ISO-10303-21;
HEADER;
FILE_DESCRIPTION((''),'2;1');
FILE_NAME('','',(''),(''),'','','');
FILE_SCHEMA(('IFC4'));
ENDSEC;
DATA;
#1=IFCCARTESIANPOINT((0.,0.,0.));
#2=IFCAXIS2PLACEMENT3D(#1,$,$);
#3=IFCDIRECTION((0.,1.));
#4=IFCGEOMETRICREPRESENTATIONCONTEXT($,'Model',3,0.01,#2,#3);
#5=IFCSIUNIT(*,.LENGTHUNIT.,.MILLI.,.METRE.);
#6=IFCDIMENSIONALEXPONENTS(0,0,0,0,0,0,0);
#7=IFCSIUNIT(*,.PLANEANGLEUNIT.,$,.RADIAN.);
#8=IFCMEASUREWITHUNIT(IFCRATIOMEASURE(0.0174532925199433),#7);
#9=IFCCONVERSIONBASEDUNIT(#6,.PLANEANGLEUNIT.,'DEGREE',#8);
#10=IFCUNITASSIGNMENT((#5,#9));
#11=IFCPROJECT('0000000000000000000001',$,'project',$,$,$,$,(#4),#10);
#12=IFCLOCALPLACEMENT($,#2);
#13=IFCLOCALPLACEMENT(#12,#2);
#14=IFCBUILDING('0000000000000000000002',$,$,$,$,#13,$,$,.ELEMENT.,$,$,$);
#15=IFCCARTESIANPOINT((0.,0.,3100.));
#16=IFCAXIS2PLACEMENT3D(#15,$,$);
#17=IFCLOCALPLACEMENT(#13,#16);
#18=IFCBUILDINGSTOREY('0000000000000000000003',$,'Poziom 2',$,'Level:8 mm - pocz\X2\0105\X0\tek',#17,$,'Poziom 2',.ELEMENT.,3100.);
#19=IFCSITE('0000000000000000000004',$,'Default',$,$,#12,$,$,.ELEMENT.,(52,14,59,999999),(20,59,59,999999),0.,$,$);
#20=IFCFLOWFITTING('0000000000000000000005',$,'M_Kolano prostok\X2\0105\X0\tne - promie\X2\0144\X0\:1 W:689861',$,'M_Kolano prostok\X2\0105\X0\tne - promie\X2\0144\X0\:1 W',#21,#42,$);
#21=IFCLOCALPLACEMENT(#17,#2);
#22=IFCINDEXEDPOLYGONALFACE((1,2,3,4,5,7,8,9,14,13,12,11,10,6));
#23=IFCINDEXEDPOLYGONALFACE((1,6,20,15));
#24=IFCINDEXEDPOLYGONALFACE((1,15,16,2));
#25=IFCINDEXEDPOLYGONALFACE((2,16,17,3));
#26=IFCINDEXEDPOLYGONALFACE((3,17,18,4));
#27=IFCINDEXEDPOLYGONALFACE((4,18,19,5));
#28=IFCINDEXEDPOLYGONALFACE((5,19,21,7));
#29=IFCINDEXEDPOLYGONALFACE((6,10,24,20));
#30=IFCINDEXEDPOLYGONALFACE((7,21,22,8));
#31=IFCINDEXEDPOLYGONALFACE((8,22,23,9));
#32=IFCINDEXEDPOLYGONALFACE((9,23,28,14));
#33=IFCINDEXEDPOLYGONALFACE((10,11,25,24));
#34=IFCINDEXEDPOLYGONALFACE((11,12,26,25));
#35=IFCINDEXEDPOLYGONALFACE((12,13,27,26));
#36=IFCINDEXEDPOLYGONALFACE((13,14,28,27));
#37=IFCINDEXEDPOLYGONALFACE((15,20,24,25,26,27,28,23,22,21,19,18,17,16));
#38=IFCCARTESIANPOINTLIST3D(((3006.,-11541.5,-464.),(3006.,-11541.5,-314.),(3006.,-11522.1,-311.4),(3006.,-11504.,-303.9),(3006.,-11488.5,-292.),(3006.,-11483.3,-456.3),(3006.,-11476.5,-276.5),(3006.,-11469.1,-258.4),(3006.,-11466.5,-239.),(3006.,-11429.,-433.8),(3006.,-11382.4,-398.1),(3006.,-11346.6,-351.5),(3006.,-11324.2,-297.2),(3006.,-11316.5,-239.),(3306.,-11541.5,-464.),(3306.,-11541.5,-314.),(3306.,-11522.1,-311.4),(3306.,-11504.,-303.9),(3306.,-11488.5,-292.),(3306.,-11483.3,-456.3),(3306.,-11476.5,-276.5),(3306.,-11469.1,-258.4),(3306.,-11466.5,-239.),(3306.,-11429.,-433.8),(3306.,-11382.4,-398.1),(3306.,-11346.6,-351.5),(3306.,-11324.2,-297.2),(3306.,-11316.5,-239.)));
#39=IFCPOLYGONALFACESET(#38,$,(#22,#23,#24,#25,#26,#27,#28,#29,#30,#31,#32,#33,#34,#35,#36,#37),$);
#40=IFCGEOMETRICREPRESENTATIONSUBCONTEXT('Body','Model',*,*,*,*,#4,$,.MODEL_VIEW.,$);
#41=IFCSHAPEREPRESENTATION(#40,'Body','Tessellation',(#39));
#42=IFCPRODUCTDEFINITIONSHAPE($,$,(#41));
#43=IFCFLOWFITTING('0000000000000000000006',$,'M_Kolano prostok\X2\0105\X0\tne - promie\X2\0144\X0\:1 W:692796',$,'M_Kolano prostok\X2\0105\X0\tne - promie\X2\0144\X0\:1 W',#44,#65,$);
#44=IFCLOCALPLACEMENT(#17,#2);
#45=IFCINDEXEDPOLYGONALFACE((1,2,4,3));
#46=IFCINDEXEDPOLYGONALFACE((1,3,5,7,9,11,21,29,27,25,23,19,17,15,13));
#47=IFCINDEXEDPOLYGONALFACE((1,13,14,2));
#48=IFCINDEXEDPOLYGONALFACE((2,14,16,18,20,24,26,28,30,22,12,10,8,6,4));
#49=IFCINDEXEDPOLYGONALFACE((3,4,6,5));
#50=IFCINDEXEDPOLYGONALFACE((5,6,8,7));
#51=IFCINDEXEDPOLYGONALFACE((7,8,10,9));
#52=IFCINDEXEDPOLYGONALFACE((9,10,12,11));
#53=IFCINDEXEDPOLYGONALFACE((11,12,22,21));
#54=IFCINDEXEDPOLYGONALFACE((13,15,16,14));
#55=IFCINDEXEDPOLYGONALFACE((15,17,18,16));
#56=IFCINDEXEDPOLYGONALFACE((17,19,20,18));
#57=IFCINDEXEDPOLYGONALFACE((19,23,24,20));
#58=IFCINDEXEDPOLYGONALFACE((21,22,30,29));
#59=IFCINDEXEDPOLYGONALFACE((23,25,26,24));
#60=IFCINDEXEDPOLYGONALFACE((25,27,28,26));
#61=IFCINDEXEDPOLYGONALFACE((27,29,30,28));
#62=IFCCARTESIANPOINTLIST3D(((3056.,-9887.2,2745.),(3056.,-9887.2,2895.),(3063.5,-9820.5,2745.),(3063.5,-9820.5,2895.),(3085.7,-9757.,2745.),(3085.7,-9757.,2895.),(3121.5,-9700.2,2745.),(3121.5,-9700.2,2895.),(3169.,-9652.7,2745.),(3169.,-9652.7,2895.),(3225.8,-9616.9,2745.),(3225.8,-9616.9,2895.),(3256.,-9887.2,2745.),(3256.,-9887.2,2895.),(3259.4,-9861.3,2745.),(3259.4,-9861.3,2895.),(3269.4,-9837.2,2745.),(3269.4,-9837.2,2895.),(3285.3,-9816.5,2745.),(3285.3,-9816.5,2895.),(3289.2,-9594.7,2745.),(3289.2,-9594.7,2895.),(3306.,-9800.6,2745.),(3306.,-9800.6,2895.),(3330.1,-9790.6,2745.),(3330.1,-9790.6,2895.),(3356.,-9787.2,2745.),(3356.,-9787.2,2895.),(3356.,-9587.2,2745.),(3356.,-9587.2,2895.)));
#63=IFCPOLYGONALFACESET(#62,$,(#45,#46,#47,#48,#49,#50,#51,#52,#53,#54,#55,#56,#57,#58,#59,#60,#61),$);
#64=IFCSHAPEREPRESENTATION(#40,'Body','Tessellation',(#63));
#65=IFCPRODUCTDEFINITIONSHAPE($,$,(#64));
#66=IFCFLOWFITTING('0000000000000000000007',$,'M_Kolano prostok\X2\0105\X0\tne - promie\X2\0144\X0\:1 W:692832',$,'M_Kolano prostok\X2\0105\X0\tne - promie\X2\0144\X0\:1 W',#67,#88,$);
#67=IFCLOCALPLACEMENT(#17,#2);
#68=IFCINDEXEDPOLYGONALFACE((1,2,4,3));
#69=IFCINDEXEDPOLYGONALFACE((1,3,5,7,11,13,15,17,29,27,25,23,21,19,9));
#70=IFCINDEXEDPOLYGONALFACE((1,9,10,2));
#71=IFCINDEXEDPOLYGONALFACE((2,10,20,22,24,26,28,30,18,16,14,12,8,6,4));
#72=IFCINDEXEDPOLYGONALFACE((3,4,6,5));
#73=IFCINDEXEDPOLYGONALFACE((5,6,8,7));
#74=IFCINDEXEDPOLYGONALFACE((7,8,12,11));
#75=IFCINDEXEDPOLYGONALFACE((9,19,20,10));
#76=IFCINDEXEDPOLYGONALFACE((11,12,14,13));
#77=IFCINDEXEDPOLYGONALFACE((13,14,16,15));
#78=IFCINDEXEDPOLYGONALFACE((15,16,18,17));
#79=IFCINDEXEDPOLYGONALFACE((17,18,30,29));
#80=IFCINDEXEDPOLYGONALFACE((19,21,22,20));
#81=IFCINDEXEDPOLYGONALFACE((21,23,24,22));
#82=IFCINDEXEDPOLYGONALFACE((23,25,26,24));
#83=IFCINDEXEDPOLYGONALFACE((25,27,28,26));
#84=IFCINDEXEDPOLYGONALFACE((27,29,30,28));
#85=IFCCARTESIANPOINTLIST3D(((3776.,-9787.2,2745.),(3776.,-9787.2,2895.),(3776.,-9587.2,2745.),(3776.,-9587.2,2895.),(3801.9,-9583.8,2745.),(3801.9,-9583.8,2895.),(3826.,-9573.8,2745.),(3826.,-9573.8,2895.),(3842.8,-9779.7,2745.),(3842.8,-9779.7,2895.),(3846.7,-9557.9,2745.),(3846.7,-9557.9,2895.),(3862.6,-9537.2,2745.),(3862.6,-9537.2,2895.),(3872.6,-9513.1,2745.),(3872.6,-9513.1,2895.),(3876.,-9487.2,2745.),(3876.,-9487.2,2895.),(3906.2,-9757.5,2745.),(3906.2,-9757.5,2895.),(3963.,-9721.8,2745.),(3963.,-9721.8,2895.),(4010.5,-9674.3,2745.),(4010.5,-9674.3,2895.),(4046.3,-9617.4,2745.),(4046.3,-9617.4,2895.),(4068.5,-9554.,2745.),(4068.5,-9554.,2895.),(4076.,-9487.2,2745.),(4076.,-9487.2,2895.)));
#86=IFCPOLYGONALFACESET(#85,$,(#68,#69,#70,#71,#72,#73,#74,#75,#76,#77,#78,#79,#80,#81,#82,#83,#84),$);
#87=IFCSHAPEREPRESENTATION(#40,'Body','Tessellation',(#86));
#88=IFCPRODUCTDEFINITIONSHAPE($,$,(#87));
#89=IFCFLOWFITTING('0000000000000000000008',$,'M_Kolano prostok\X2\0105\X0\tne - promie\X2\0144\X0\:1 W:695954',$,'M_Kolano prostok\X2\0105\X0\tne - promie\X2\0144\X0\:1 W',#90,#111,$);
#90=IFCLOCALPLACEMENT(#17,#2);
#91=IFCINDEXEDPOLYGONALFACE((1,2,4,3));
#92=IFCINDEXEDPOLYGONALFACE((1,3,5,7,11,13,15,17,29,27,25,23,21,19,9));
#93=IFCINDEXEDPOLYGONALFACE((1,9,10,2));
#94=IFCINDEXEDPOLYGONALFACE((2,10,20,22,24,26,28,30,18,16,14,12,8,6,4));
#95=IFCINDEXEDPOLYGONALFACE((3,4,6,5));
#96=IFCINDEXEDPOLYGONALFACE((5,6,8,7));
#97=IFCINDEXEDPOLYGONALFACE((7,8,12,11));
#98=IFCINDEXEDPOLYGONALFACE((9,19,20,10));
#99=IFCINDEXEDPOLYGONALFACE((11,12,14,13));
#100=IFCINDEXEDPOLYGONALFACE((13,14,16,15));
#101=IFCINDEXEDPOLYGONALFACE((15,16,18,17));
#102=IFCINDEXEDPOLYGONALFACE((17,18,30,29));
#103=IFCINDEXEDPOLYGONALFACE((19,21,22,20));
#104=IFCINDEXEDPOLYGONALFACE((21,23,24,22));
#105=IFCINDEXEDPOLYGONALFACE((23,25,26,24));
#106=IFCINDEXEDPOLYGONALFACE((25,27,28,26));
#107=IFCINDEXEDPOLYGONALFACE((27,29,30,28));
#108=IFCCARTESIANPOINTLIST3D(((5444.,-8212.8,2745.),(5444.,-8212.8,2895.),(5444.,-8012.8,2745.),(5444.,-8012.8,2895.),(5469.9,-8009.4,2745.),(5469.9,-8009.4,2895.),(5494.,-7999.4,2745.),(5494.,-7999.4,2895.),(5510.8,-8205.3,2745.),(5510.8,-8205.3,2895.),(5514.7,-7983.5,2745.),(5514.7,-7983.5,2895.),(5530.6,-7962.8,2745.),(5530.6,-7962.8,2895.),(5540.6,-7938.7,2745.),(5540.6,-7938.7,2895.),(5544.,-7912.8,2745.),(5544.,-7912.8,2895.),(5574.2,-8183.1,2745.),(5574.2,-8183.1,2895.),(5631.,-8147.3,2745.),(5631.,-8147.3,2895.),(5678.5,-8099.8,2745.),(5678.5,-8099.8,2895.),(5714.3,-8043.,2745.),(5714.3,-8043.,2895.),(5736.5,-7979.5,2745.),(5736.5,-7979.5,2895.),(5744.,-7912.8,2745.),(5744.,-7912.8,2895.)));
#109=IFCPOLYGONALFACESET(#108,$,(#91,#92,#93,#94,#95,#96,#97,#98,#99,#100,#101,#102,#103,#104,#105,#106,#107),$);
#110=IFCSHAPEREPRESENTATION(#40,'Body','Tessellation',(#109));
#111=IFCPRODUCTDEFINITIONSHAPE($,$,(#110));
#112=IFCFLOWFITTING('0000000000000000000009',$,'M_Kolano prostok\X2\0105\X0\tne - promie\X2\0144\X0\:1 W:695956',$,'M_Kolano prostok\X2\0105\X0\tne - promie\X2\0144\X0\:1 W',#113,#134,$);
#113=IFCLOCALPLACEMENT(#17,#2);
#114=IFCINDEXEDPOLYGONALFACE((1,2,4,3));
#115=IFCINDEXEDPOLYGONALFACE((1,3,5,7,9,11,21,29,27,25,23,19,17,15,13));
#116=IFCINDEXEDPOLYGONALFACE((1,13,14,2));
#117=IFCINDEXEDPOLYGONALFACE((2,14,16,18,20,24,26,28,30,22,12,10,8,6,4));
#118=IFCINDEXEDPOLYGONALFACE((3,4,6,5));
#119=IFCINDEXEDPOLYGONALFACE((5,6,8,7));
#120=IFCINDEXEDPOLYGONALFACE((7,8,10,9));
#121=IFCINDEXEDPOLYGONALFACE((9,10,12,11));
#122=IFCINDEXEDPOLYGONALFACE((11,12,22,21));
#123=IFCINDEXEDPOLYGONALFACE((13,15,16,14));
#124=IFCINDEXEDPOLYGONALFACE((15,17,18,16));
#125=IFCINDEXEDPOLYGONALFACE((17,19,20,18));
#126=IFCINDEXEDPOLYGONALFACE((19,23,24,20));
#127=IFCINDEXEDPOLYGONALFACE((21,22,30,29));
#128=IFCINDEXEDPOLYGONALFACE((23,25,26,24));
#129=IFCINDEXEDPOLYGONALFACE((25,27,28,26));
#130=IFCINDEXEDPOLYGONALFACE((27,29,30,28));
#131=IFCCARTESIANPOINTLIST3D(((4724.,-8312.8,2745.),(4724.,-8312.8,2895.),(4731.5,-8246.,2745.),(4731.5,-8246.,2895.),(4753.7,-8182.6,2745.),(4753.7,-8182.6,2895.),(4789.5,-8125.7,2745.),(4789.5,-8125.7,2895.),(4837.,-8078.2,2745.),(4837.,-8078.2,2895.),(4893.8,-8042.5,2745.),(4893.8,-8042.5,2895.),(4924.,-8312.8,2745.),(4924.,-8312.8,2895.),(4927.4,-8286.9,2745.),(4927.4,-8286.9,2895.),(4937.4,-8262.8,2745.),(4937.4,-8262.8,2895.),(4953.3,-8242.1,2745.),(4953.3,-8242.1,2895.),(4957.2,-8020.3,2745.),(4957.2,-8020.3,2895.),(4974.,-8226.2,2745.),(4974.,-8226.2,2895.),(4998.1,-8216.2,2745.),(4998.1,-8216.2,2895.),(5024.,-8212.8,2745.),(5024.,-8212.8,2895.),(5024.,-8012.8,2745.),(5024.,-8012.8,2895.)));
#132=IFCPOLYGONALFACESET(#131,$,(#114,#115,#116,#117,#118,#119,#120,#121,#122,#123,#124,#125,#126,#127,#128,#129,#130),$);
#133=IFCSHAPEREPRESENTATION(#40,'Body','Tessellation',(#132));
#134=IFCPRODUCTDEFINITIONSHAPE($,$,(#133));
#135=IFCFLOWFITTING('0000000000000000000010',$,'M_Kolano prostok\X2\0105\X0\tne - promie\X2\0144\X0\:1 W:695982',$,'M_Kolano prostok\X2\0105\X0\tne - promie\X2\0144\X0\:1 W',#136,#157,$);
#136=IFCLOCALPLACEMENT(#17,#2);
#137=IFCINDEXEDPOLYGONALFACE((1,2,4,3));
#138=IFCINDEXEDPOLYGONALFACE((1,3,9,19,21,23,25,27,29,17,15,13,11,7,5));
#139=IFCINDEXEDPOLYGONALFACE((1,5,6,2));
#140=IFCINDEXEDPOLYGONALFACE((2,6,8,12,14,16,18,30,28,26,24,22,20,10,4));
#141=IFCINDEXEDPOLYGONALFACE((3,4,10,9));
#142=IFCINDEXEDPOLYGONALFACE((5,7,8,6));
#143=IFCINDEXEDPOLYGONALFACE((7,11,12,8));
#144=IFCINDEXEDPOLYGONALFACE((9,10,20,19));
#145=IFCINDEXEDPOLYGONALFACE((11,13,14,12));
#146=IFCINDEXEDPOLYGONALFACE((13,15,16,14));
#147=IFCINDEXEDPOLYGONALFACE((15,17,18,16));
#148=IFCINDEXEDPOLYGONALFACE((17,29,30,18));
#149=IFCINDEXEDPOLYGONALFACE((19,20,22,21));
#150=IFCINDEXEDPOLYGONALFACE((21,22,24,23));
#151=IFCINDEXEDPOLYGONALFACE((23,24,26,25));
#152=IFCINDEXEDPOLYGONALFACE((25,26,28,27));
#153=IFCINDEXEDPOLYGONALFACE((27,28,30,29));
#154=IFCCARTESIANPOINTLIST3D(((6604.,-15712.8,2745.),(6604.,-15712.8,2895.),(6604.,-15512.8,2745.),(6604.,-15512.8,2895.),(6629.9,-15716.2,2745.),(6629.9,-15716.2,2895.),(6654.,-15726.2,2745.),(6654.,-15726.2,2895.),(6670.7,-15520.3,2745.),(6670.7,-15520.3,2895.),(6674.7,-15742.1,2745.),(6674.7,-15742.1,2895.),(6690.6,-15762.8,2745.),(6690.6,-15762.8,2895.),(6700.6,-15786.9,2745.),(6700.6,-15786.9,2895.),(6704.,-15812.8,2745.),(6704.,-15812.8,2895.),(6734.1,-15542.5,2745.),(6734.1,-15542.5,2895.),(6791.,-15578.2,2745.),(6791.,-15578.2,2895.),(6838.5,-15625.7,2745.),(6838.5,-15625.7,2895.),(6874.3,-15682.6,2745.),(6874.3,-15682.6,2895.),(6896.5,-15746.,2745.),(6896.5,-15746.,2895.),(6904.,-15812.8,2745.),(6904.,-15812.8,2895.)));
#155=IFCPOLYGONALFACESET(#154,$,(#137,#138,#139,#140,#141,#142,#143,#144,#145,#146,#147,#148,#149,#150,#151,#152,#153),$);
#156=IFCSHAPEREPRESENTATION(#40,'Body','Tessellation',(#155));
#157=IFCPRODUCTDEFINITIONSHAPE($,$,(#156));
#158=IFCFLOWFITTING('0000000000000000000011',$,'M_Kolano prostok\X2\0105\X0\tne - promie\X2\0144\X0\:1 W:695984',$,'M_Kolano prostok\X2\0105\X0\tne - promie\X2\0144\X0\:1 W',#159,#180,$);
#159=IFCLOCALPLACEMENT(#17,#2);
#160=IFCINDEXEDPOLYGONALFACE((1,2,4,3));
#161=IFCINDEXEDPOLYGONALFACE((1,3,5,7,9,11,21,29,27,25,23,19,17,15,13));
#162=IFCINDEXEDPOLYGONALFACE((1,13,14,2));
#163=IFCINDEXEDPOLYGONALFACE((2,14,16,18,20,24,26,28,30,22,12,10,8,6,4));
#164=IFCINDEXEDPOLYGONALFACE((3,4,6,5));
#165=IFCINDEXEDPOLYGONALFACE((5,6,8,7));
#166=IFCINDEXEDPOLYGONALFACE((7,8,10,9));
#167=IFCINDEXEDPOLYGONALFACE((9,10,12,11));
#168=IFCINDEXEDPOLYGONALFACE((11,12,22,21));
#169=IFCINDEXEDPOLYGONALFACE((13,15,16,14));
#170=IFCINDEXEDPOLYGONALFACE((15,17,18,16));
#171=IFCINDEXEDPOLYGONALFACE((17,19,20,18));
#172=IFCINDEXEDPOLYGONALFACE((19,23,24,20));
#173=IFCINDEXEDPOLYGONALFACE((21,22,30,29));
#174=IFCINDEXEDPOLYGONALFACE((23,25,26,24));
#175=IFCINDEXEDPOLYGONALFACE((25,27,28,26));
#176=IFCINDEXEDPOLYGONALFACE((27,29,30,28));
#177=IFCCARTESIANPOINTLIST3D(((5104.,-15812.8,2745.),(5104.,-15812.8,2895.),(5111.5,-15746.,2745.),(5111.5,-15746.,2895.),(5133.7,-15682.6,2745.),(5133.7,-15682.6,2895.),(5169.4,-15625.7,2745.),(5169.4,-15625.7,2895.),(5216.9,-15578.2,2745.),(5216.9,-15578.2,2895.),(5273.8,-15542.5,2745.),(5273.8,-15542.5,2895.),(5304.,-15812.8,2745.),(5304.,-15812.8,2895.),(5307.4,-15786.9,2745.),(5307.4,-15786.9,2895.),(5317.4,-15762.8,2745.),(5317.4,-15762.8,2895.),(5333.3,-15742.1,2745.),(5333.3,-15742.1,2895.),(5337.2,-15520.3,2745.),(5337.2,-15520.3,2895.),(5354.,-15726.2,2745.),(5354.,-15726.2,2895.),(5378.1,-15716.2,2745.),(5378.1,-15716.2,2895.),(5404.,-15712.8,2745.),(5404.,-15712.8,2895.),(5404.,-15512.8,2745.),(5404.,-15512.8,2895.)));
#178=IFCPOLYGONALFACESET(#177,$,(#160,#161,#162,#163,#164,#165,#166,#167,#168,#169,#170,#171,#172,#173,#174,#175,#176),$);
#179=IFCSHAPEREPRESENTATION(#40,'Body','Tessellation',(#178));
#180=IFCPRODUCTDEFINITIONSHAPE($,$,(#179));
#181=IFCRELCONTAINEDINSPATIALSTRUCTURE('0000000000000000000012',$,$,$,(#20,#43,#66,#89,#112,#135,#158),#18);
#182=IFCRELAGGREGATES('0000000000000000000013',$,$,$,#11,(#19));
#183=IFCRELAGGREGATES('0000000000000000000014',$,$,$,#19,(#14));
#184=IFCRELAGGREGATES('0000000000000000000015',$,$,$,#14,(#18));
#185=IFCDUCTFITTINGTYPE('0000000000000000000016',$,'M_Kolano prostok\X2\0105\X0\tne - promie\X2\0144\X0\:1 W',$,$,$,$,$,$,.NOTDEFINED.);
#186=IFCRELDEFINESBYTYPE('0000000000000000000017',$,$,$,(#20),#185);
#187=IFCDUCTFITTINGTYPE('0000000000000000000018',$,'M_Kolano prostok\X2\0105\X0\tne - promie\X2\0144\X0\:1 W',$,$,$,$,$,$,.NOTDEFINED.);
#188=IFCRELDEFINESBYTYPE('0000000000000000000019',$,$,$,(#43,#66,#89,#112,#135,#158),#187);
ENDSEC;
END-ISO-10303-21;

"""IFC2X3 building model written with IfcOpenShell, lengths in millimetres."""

from ifc_helpers import new_model, entity, si_unit, converted_unit, direction, frame, frame_2d, origin, place, context, subcontext, project, spatial, polyline, circle_curve, parameter, trimmed, segment, composite_curve, outline, extrude, source, transform, mapped, type_object, type_shapes, element, save


model = new_model("IFC2X3")

# Units and contexts
model_context = context("Model", 3, precision=0.01, world=origin(), true_north=direction((0.0, 1.0)))
body_context = subcontext(model_context, "Body", "Model", "MODEL_VIEW")
ifc_project = project(units=[si_unit("LENGTHUNIT", "METRE", prefix="MILLI"), converted_unit("PLANEANGLEUNIT", "DEGREE", entity("IfcRatioMeasure", 0.0174532925199433), si_unit("PLANEANGLEUNIT", "RADIAN"), dimensions=[0, 0, 0, 0, 0, 0, 0])], contexts=[model_context])

# Site, building, storey
site_placement = place(None, origin())
site = spatial("IfcSite", under=ifc_project, at=site_placement, Name="Default", CompositionType="ELEMENT", RefLatitude=(52, 14, 59, 999999), RefLongitude=(20, 59, 59, 999999), RefElevation=0.0)
building_placement = place(site_placement, origin())
building = spatial("IfcBuilding", under=site, at=building_placement, CompositionType="ELEMENT")
storey_placement = place(building_placement, frame((0.0, 0.0, 3100.0)))
storey = spatial("IfcBuildingStorey", under=building, at=storey_placement, Name="Poziom 2", ObjectType="Level:8 mm - początek", LongName="Poziom 2", CompositionType="ELEMENT", Elevation=3100.0)

# Flow fittings
duct_fitting_type_1 = type_object("IfcDuctFittingType", Name="M_Kolano prostokątne - promień:1 W", PredefinedType="NOTDEFINED")
shared_shape_1 = source(origin(), body_context, "Body", "SweptSolid", [
    extrude(outline(composite_curve([segment(polyline([(-150.0, -75.0), (0.0, -75.0)]), True, "CONTINUOUS"), segment(trimmed(circle_curve(frame_2d((75.0, -75.0), x_axis=(0.0, 1.0)), 75.0), [parameter(0.0)], [parameter(90.0)], True, "PARAMETER"), False, "CONTINUOUS"), segment(polyline([(75.0, 0.0), (75.0, 150.0)]), True, "CONTINUOUS"), segment(trimmed(circle_curve(frame_2d((75.0, -75.0), x_axis=(0.0, 1.0)), 225.0), [parameter(0.0)], [parameter(90.0)], True, "PARAMETER"), True, "CONTINUOUS")], self_intersect=False)), frame((-75.0, 75.0, -150.0), z_axis=(0.0, 0.0, 1.0), x_axis=(-1.0, 0.0, 0.0)), (0.0, 0.0, 1.0), 300.0),
])
type_shapes(duct_fitting_type_1, [shared_shape_1])
flow_fitting_1_placement = place(storey_placement, frame((3156.0, -11391.5, -389.0), z_axis=(-1.0, 0.0, 0.0), x_axis=(0.0, 0.0, -1.0)))
element("IfcFlowFitting", 1, at=flow_fitting_1_placement, inside=storey, type_object=duct_fitting_type_1, Name="M_Kolano prostokątne - promień:1 W:689861", ObjectType="M_Kolano prostokątne - promień:1 W", context=body_context, shape_type="MappedRepresentation", body=[
    mapped(shared_shape_1, transform((0.0, 0.0, 0.0), scale=1.0)),
])
duct_fitting_type_2 = type_object("IfcDuctFittingType", Name="M_Kolano prostokątne - promień:1 W", PredefinedType="NOTDEFINED")
shared_shape_2 = source(origin(), body_context, "Body", "SweptSolid", [
    extrude(outline(composite_curve([segment(polyline([(-200.0, -100.0), (0.0, -100.0)]), True, "CONTINUOUS"), segment(trimmed(circle_curve(frame_2d((100.0, -100.0), x_axis=(0.0, 1.0)), 100.0), [parameter(0.0)], [parameter(90.0)], True, "PARAMETER"), False, "CONTINUOUS"), segment(polyline([(100.0, 0.0), (100.0, 200.0)]), True, "CONTINUOUS"), segment(trimmed(circle_curve(frame_2d((100.0, -100.0), x_axis=(0.0, 1.0)), 300.0), [parameter(0.0)], [parameter(90.0)], True, "PARAMETER"), True, "CONTINUOUS")], self_intersect=False)), frame((-100.0, 100.0, -75.0), z_axis=(0.0, 0.0, 1.0), x_axis=(-1.0, 0.0, 0.0)), (0.0, 0.0, 1.0), 150.0),
])
type_shapes(duct_fitting_type_2, [shared_shape_2])
flow_fitting_2_placement = place(storey_placement, frame((3156.0, -9687.2, 2820.0), z_axis=(0.0, 0.0, 1.0), x_axis=(-1.0, 0.0, 0.0)))
element("IfcFlowFitting", 2, at=flow_fitting_2_placement, inside=storey, type_object=duct_fitting_type_2, Name="M_Kolano prostokątne - promień:1 W:692796", ObjectType="M_Kolano prostokątne - promień:1 W", context=body_context, shape_type="MappedRepresentation", body=[
    mapped(shared_shape_2, transform((0.0, 0.0, 0.0), scale=1.0)),
])
for number, where, name in (
    (3, (3976.0, -9687.2, 2820.0), "M_Kolano prostokątne - promień:1 W:692832"),
    (4, (5644.0, -8112.8, 2820.0), "M_Kolano prostokątne - promień:1 W:695954"),
):
    element("IfcFlowFitting", number, at=place(storey_placement, frame(where)), inside=storey, type_object=duct_fitting_type_2, Name=name, ObjectType="M_Kolano prostokątne - promień:1 W", context=body_context, shape_type="MappedRepresentation", body=[
        mapped(shared_shape_2, transform((0.0, 0.0, 0.0), scale=1.0)),
    ])
for number, where, z_axis, x_axis, name in (
    (5, (4824.0, -8112.8, 2820.0), (0.0, 0.0, 1.0), (-1.0, 0.0, 0.0), "M_Kolano prostokątne - promień:1 W:695956"),
    (6, (6804.0, -15612.8, 2820.0), (0.0, 0.0, 1.0), (0.0, 1.0, 0.0), "M_Kolano prostokątne - promień:1 W:695982"),
    (7, (5204.0, -15612.8, 2820.0), (0.0, 0.0, 1.0), (-1.0, 0.0, 0.0), "M_Kolano prostokątne - promień:1 W:695984"),
):
    element("IfcFlowFitting", number, at=place(storey_placement, frame(where, z_axis=z_axis, x_axis=x_axis)), inside=storey, type_object=duct_fitting_type_2, Name=name, ObjectType="M_Kolano prostokątne - promień:1 W", context=body_context, shape_type="MappedRepresentation", body=[
        mapped(shared_shape_2, transform((0.0, 0.0, 0.0), scale=1.0)),
    ])

save(model, "model.ifc")
